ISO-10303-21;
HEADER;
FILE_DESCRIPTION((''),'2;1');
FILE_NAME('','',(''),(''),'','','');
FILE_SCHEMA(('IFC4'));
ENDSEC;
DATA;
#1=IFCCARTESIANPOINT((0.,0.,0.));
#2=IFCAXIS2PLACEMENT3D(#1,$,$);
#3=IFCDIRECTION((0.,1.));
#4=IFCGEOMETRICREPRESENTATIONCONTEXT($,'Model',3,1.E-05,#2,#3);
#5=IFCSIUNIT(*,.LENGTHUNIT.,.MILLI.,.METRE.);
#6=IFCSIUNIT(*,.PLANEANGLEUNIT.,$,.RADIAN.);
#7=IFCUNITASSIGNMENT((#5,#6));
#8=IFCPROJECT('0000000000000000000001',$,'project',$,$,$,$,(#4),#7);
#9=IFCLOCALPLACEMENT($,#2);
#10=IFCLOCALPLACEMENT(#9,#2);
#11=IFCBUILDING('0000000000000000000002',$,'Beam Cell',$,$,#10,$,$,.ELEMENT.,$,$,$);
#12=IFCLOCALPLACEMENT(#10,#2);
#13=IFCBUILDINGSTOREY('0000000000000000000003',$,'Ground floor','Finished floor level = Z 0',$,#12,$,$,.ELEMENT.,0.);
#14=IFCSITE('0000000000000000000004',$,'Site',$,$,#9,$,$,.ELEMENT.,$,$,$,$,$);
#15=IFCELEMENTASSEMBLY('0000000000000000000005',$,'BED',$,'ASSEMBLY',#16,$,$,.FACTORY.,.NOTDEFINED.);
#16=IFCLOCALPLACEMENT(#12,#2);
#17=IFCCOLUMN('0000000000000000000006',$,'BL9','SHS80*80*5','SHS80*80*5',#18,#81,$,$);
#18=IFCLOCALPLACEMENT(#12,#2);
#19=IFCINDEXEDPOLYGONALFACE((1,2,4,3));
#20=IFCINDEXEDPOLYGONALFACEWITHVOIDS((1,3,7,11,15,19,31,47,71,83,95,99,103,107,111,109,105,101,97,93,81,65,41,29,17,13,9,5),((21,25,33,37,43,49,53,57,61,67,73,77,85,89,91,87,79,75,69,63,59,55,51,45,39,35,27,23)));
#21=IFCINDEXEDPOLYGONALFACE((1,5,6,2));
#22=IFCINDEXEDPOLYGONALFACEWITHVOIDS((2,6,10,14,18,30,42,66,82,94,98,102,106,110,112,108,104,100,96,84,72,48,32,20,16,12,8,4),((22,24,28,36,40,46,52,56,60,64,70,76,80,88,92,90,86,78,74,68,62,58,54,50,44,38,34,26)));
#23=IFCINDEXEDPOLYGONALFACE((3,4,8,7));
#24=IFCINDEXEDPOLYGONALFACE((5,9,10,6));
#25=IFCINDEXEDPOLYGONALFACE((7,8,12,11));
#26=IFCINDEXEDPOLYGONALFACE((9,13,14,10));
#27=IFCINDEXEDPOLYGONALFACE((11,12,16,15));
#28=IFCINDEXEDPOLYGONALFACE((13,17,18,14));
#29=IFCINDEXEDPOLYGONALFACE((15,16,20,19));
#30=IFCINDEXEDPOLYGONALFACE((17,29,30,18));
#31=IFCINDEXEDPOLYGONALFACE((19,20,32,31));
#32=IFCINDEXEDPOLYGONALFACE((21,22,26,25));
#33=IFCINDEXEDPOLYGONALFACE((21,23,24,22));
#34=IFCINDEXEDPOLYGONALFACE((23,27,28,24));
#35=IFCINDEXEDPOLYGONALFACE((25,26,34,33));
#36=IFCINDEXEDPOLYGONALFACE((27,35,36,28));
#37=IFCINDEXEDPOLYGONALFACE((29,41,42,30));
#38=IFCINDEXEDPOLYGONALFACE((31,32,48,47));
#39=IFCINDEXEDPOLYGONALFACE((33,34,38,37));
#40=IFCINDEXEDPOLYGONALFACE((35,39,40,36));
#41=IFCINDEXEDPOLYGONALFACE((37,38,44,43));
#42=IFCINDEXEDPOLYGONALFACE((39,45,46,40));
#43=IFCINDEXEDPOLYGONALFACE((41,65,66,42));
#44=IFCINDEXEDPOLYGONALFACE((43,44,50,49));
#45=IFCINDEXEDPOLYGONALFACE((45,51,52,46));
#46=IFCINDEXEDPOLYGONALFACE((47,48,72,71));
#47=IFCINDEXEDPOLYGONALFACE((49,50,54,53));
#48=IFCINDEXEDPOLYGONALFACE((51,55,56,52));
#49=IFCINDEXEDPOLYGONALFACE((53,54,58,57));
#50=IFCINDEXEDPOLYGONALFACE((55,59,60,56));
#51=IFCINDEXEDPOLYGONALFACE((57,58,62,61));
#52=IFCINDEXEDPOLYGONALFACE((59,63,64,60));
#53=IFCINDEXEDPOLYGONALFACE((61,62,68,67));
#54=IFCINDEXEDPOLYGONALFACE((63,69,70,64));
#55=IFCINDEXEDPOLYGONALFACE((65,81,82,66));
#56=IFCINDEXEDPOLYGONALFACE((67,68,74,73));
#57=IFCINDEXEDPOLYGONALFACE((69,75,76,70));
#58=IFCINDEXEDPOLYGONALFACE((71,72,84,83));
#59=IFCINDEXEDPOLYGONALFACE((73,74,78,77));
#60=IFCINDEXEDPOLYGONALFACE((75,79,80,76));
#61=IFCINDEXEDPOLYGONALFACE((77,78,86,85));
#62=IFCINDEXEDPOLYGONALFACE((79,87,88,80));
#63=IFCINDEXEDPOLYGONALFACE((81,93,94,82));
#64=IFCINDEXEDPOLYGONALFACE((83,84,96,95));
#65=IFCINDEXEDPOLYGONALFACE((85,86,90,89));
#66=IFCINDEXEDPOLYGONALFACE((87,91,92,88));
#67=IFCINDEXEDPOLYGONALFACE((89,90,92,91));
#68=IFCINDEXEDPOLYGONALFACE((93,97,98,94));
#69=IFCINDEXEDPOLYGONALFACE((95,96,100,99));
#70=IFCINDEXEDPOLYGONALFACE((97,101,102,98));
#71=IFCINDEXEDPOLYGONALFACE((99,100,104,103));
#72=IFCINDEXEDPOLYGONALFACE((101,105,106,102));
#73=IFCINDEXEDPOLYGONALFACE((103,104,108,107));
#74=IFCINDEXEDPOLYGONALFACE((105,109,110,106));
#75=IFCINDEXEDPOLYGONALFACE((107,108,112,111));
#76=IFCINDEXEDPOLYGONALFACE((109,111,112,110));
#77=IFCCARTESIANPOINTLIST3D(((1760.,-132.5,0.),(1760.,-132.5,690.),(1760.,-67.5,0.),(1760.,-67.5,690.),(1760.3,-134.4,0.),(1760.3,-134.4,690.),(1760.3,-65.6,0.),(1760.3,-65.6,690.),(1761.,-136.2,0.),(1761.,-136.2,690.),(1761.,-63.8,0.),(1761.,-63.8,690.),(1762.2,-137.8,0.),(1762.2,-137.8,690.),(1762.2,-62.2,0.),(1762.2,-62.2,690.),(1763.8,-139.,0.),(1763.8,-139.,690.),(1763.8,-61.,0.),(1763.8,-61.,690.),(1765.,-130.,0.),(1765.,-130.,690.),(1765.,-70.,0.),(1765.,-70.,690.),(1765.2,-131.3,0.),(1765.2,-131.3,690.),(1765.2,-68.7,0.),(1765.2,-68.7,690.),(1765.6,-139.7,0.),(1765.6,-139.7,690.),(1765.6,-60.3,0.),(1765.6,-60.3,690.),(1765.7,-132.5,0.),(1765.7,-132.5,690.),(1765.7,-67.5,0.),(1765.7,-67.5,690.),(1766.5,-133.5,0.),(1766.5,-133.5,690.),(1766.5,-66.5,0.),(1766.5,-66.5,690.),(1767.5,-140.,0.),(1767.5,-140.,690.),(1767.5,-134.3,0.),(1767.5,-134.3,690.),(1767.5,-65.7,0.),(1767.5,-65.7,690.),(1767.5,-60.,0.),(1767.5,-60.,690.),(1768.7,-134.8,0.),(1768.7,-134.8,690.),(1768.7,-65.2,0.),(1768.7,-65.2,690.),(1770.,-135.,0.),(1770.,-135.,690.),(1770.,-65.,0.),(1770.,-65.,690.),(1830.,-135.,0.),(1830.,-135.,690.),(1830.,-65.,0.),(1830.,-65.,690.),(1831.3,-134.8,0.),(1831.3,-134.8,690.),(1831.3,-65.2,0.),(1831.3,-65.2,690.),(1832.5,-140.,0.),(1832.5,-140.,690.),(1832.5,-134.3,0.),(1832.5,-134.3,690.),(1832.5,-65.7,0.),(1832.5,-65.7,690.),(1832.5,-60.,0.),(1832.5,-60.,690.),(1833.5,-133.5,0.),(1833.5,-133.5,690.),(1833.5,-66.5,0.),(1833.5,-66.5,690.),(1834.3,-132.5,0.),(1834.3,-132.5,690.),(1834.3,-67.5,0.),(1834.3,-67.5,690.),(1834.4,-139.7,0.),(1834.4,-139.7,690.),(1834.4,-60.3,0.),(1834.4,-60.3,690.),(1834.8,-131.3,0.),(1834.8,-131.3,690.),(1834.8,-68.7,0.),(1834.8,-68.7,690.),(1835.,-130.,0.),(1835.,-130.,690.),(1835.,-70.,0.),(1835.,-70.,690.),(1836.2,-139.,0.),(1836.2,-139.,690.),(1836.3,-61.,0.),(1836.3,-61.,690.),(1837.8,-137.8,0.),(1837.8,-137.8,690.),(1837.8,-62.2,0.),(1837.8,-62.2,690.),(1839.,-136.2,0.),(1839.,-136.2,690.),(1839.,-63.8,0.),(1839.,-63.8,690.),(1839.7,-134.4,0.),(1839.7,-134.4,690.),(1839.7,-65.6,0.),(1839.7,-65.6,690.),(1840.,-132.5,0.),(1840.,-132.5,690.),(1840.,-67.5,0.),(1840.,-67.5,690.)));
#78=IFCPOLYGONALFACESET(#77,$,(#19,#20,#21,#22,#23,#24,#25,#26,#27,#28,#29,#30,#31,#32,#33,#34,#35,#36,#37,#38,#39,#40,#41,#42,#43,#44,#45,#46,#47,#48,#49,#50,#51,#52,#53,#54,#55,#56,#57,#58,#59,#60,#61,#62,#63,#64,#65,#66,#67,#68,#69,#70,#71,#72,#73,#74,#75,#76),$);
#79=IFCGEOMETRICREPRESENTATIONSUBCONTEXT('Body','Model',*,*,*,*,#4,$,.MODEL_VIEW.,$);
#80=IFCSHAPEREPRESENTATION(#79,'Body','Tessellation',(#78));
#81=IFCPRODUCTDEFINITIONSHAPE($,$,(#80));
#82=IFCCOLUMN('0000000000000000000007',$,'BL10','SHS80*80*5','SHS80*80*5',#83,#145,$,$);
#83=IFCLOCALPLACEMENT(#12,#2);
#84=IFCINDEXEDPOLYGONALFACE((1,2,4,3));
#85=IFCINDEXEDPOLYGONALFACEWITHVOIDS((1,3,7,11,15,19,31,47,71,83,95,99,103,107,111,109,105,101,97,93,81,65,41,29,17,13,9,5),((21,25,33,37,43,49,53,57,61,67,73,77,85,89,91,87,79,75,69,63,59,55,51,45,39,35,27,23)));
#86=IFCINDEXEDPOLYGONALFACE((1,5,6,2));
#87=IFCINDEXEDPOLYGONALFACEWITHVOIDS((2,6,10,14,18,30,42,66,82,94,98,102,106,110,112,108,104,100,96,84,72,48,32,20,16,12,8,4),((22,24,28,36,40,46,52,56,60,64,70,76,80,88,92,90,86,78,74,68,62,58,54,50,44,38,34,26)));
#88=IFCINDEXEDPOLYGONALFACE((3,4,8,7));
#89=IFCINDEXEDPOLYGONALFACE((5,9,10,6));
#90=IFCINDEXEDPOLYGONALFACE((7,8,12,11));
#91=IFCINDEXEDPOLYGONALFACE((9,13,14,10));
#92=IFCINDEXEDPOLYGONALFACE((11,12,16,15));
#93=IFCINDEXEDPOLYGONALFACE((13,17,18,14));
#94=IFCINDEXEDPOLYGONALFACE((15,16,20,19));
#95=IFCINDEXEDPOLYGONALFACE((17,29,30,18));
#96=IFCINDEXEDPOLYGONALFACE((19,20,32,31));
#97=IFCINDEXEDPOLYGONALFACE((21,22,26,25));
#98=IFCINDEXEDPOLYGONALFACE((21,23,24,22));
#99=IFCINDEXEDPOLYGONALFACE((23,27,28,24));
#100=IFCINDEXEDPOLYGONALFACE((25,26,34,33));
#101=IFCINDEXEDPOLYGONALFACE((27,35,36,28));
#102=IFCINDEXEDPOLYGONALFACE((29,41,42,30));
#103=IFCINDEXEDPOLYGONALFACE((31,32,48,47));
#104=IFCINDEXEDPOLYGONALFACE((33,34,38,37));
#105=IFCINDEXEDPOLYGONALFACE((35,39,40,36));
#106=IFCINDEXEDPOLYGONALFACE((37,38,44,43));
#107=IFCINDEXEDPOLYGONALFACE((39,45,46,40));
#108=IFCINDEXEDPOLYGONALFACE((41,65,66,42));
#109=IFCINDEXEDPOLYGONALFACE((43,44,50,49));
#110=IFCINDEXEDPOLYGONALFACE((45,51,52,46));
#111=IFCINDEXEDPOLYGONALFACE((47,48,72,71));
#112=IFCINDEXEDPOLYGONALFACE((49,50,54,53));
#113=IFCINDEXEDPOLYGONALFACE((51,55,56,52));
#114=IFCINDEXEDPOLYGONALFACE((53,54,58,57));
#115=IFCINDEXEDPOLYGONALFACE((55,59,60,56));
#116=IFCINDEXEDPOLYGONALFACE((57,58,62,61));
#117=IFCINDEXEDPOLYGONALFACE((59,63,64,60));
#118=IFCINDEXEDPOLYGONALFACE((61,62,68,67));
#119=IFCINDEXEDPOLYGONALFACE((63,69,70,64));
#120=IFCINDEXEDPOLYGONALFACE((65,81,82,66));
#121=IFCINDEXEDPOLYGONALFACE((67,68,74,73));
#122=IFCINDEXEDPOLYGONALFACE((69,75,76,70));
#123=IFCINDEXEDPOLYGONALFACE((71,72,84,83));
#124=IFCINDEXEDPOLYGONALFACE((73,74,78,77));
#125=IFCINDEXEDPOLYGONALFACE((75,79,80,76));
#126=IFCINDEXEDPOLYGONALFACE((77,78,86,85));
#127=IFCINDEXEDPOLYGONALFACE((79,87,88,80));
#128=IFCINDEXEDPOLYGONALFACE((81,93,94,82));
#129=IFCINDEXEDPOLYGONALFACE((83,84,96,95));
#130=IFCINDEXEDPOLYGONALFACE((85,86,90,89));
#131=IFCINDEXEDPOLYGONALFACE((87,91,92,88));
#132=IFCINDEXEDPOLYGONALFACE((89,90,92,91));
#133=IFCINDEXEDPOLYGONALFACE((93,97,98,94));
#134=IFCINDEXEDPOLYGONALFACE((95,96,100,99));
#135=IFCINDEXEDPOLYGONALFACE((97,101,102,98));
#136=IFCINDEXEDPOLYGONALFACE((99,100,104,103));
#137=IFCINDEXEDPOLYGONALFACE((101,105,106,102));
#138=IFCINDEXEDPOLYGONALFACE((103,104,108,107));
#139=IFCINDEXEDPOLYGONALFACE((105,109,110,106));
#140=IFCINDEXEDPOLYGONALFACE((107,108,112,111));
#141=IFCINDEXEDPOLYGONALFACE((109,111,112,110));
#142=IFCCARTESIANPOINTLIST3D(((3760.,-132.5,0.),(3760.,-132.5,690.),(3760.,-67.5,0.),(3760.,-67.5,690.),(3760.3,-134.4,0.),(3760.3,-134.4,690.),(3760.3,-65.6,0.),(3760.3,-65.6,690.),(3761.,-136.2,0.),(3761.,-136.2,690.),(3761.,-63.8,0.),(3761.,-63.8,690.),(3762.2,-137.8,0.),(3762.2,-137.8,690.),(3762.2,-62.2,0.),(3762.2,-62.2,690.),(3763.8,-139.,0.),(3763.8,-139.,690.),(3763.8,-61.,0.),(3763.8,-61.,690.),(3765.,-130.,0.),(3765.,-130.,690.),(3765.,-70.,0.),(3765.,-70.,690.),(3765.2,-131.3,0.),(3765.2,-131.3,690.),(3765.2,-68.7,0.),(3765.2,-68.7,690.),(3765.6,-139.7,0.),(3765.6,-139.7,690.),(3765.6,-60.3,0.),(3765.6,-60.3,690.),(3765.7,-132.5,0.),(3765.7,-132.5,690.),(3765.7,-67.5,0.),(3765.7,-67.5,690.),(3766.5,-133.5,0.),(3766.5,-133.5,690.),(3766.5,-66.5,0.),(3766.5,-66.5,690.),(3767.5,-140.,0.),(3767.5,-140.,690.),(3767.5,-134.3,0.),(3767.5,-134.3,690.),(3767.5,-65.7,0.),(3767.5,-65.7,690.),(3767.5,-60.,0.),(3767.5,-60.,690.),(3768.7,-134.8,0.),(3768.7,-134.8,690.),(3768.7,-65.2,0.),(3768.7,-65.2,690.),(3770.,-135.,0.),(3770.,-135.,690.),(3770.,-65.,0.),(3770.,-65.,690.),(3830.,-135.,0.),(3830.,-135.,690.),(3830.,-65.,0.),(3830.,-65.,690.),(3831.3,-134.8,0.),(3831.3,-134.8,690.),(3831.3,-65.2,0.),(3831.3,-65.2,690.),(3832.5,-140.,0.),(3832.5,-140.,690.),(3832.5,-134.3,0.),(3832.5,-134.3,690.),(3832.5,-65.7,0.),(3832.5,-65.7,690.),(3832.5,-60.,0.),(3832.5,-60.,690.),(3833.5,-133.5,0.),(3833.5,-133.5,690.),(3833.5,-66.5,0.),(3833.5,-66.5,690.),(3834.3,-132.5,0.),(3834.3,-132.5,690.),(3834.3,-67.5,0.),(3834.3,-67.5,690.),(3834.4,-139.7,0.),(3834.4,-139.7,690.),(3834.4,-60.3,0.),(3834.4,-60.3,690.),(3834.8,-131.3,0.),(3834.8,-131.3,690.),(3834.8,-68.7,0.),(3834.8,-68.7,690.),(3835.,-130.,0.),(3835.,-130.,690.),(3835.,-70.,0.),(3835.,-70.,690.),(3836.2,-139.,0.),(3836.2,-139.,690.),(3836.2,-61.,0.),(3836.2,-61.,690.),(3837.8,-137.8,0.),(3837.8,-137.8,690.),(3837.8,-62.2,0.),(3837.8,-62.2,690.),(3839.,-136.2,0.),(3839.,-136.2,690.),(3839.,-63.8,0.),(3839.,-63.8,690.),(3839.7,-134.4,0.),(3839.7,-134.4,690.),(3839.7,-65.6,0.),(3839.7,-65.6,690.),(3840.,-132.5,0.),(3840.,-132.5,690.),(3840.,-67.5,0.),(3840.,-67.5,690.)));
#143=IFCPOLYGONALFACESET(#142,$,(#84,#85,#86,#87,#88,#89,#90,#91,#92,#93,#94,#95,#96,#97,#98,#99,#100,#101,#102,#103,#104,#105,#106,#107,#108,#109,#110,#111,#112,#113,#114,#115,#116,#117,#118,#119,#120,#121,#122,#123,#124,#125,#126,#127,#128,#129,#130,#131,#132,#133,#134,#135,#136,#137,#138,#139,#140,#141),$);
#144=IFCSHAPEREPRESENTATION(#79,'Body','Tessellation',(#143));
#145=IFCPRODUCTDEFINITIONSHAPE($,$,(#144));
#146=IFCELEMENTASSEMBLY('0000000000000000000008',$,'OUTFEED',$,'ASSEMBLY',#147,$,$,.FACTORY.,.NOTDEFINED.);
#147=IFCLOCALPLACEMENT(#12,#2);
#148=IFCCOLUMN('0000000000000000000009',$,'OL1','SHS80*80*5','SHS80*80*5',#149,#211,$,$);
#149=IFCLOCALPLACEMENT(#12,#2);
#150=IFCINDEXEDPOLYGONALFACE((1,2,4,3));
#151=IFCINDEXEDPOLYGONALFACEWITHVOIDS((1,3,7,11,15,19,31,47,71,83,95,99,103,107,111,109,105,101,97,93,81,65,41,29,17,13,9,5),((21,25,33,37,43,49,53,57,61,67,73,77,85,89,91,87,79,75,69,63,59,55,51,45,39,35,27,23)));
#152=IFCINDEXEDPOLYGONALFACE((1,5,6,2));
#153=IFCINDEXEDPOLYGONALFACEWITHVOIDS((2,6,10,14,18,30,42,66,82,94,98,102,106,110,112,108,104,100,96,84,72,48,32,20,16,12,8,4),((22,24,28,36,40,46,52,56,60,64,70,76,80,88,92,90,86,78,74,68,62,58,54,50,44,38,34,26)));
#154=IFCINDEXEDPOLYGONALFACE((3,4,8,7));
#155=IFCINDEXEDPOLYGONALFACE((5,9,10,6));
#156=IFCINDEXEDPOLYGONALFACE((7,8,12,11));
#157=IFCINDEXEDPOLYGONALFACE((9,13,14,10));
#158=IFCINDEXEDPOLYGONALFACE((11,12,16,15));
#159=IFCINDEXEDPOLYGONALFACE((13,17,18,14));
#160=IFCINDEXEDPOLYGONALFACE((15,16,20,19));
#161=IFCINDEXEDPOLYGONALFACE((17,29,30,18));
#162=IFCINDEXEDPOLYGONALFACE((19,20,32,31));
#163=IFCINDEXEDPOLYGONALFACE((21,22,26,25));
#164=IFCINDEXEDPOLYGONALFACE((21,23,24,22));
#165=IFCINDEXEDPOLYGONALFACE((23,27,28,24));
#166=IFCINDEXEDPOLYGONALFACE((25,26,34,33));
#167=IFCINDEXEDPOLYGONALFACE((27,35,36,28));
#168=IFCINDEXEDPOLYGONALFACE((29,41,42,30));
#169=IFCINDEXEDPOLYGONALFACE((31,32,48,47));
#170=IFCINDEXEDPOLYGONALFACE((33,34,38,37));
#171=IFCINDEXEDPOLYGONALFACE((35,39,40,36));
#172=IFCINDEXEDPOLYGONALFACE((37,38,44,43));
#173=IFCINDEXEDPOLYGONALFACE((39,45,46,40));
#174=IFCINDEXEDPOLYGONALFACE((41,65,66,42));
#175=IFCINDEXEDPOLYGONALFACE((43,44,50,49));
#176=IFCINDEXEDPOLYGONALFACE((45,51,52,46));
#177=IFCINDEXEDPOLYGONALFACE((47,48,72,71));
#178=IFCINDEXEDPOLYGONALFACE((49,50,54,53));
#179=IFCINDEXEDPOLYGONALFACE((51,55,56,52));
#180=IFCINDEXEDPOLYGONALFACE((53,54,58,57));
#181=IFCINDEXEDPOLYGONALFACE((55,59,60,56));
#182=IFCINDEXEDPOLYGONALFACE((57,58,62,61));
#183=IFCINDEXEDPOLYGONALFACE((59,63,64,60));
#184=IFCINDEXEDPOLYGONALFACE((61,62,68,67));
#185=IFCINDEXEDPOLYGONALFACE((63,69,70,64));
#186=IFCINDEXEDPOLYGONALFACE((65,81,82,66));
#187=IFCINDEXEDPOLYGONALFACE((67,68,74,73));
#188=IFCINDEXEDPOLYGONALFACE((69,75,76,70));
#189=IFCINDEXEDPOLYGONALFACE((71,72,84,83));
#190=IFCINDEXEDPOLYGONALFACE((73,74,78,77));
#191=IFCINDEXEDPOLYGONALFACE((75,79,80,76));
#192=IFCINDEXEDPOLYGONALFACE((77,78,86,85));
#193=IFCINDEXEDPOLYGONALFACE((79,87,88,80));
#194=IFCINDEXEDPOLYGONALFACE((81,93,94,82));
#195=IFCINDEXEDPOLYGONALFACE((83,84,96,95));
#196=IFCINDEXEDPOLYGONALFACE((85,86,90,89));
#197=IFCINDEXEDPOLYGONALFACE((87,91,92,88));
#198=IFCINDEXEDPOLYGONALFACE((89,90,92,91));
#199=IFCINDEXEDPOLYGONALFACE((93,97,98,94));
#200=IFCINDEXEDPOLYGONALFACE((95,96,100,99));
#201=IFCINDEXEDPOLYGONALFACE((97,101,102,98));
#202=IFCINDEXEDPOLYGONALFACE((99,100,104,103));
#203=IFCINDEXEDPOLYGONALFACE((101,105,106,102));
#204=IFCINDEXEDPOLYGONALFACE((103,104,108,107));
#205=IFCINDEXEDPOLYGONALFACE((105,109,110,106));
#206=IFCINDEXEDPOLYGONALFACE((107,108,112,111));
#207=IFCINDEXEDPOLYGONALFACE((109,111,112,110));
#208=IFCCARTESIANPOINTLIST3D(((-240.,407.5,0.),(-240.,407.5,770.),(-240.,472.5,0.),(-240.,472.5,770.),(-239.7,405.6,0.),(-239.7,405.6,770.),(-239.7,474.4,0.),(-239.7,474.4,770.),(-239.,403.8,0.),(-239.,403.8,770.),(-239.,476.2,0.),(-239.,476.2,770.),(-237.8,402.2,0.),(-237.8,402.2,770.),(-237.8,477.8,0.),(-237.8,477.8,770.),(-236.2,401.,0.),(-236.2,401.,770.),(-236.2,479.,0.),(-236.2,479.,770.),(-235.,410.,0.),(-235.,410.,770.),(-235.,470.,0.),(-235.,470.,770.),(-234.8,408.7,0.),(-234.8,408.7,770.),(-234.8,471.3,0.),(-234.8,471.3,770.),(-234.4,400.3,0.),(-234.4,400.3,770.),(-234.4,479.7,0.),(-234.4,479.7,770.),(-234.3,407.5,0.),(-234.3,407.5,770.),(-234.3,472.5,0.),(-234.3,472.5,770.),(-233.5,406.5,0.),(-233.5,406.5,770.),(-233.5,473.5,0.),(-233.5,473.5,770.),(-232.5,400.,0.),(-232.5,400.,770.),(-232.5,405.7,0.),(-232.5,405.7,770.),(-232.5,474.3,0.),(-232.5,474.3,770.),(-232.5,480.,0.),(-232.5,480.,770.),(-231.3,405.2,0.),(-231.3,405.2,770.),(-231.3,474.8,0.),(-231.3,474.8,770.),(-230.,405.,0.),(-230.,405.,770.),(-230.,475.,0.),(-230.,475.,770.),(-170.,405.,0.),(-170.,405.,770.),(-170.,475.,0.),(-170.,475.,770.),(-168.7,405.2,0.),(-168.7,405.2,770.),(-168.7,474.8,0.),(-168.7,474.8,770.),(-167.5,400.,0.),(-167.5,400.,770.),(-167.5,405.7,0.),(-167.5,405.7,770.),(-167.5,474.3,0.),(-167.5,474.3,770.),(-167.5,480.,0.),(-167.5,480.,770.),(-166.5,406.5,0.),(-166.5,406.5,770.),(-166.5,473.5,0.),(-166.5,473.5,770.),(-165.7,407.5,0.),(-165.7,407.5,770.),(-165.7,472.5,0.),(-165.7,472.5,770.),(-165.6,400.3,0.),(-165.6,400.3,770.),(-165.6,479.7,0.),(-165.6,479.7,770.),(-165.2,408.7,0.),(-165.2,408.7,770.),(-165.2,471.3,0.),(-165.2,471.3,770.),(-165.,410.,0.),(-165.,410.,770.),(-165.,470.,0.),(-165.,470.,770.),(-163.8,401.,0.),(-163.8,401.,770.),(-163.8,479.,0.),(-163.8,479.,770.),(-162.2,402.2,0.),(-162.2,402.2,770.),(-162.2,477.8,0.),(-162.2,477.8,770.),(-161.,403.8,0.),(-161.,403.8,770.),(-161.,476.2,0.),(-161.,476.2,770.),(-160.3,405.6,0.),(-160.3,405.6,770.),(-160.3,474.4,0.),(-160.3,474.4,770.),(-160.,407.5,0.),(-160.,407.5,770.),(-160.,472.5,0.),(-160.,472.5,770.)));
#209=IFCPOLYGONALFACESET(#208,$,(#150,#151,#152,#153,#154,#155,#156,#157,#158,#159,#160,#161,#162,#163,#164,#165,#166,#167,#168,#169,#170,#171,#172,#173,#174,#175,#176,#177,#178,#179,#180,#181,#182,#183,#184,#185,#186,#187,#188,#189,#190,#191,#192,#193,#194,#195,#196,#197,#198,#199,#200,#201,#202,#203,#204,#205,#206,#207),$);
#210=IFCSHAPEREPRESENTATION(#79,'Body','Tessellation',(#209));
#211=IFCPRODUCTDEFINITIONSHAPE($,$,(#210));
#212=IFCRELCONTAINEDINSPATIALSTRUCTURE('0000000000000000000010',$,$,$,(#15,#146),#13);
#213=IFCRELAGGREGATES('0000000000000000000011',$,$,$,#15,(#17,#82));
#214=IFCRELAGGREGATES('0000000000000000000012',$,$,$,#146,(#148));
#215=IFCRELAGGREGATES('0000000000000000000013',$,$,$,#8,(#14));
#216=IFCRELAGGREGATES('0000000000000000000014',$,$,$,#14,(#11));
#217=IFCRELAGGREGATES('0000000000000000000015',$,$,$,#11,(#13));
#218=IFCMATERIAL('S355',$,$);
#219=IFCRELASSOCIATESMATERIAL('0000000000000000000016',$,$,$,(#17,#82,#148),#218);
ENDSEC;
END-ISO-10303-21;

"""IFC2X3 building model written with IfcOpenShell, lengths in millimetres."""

from ifc_helpers import new_model, si_unit, direction, frame, origin, origin_2d, place, context, subcontext, project, spatial, hollow_rectangle, extrude, material, element, aggregate, save


model = new_model("IFC2X3")

# Units and contexts
model_context = context("Model", 3, precision=1e-05, world=origin(), true_north=direction((0.0, 1.0)))
body_context = subcontext(model_context, "Body", "Model", "MODEL_VIEW")
ifc_project = project(units=[si_unit("LENGTHUNIT", "METRE", prefix="MILLI"), si_unit("PLANEANGLEUNIT", "RADIAN")], contexts=[model_context])

# Site, building, storey
site_placement = place(None, origin())
site = spatial("IfcSite", under=ifc_project, at=site_placement, Name="Site", CompositionType="ELEMENT")
building_placement = place(site_placement, origin())
building = spatial("IfcBuilding", under=site, at=building_placement, Name="Beam Cell", CompositionType="ELEMENT")
storey_placement = place(building_placement, origin())
storey = spatial("IfcBuildingStorey", under=building, at=storey_placement, Name="Ground floor", Description="Finished floor level = Z 0", CompositionType="ELEMENT", Elevation=0.0)

# Shared definitions
ifc_material = material(Name="S355")

# Element assemblies, columns
assembly_1_placement = place(storey_placement, origin())
assembly_1 = element("IfcElementAssembly", 1, at=assembly_1_placement, inside=storey, Name="BED", ObjectType="ASSEMBLY", AssemblyPlace="FACTORY", PredefinedType="NOTDEFINED")
column_1_placement = place(storey_placement, frame((1800.0, -100.0, 0.0), z_axis=(0.0, 0.0, 1.0), x_axis=(1.0, 0.0, 0.0)))
column_1 = element("IfcColumn", 2, at=column_1_placement, material=ifc_material, Name="BL9", Description="SHS80*80*5", ObjectType="SHS80*80*5", context=body_context, shape_type="SweptSolid", body=[
    extrude(hollow_rectangle(XDim=80.0, YDim=80.0, WallThickness=5.0, InnerFilletRadius=5.0, OuterFilletRadius=7.5, at=origin_2d()), origin(), (0.0, 0.0, 1.0), 690.0),
])
column_2_placement = place(storey_placement, frame((3800.0, -100.0, 0.0), z_axis=(0.0, 0.0, 1.0), x_axis=(1.0, 0.0, 0.0)))
column_2 = element("IfcColumn", 3, at=column_2_placement, material=ifc_material, Name="BL10", Description="SHS80*80*5", ObjectType="SHS80*80*5", context=body_context, shape_type="SweptSolid", body=[
    extrude(hollow_rectangle(XDim=80.0, YDim=80.0, WallThickness=5.0, InnerFilletRadius=5.0, OuterFilletRadius=7.5, at=origin_2d()), origin(), (0.0, 0.0, 1.0), 690.0),
])
aggregate(assembly_1, [column_1, column_2])
assembly_2_placement = place(storey_placement, origin())
assembly_2 = element("IfcElementAssembly", 4, at=assembly_2_placement, inside=storey, Name="OUTFEED", ObjectType="ASSEMBLY", AssemblyPlace="FACTORY", PredefinedType="NOTDEFINED")
column_3_placement = place(storey_placement, frame((-200.0, 440.0, 0.0), z_axis=(0.0, 0.0, 1.0), x_axis=(1.0, 0.0, 0.0)))
column_3 = element("IfcColumn", 5, at=column_3_placement, material=ifc_material, Name="OL1", Description="SHS80*80*5", ObjectType="SHS80*80*5", context=body_context, shape_type="SweptSolid", body=[
    extrude(hollow_rectangle(XDim=80.0, YDim=80.0, WallThickness=5.0, InnerFilletRadius=5.0, OuterFilletRadius=7.5, at=origin_2d()), origin(), (0.0, 0.0, 1.0), 770.0),
])

aggregate(assembly_2, [column_3])

save(model, "model.ifc")
